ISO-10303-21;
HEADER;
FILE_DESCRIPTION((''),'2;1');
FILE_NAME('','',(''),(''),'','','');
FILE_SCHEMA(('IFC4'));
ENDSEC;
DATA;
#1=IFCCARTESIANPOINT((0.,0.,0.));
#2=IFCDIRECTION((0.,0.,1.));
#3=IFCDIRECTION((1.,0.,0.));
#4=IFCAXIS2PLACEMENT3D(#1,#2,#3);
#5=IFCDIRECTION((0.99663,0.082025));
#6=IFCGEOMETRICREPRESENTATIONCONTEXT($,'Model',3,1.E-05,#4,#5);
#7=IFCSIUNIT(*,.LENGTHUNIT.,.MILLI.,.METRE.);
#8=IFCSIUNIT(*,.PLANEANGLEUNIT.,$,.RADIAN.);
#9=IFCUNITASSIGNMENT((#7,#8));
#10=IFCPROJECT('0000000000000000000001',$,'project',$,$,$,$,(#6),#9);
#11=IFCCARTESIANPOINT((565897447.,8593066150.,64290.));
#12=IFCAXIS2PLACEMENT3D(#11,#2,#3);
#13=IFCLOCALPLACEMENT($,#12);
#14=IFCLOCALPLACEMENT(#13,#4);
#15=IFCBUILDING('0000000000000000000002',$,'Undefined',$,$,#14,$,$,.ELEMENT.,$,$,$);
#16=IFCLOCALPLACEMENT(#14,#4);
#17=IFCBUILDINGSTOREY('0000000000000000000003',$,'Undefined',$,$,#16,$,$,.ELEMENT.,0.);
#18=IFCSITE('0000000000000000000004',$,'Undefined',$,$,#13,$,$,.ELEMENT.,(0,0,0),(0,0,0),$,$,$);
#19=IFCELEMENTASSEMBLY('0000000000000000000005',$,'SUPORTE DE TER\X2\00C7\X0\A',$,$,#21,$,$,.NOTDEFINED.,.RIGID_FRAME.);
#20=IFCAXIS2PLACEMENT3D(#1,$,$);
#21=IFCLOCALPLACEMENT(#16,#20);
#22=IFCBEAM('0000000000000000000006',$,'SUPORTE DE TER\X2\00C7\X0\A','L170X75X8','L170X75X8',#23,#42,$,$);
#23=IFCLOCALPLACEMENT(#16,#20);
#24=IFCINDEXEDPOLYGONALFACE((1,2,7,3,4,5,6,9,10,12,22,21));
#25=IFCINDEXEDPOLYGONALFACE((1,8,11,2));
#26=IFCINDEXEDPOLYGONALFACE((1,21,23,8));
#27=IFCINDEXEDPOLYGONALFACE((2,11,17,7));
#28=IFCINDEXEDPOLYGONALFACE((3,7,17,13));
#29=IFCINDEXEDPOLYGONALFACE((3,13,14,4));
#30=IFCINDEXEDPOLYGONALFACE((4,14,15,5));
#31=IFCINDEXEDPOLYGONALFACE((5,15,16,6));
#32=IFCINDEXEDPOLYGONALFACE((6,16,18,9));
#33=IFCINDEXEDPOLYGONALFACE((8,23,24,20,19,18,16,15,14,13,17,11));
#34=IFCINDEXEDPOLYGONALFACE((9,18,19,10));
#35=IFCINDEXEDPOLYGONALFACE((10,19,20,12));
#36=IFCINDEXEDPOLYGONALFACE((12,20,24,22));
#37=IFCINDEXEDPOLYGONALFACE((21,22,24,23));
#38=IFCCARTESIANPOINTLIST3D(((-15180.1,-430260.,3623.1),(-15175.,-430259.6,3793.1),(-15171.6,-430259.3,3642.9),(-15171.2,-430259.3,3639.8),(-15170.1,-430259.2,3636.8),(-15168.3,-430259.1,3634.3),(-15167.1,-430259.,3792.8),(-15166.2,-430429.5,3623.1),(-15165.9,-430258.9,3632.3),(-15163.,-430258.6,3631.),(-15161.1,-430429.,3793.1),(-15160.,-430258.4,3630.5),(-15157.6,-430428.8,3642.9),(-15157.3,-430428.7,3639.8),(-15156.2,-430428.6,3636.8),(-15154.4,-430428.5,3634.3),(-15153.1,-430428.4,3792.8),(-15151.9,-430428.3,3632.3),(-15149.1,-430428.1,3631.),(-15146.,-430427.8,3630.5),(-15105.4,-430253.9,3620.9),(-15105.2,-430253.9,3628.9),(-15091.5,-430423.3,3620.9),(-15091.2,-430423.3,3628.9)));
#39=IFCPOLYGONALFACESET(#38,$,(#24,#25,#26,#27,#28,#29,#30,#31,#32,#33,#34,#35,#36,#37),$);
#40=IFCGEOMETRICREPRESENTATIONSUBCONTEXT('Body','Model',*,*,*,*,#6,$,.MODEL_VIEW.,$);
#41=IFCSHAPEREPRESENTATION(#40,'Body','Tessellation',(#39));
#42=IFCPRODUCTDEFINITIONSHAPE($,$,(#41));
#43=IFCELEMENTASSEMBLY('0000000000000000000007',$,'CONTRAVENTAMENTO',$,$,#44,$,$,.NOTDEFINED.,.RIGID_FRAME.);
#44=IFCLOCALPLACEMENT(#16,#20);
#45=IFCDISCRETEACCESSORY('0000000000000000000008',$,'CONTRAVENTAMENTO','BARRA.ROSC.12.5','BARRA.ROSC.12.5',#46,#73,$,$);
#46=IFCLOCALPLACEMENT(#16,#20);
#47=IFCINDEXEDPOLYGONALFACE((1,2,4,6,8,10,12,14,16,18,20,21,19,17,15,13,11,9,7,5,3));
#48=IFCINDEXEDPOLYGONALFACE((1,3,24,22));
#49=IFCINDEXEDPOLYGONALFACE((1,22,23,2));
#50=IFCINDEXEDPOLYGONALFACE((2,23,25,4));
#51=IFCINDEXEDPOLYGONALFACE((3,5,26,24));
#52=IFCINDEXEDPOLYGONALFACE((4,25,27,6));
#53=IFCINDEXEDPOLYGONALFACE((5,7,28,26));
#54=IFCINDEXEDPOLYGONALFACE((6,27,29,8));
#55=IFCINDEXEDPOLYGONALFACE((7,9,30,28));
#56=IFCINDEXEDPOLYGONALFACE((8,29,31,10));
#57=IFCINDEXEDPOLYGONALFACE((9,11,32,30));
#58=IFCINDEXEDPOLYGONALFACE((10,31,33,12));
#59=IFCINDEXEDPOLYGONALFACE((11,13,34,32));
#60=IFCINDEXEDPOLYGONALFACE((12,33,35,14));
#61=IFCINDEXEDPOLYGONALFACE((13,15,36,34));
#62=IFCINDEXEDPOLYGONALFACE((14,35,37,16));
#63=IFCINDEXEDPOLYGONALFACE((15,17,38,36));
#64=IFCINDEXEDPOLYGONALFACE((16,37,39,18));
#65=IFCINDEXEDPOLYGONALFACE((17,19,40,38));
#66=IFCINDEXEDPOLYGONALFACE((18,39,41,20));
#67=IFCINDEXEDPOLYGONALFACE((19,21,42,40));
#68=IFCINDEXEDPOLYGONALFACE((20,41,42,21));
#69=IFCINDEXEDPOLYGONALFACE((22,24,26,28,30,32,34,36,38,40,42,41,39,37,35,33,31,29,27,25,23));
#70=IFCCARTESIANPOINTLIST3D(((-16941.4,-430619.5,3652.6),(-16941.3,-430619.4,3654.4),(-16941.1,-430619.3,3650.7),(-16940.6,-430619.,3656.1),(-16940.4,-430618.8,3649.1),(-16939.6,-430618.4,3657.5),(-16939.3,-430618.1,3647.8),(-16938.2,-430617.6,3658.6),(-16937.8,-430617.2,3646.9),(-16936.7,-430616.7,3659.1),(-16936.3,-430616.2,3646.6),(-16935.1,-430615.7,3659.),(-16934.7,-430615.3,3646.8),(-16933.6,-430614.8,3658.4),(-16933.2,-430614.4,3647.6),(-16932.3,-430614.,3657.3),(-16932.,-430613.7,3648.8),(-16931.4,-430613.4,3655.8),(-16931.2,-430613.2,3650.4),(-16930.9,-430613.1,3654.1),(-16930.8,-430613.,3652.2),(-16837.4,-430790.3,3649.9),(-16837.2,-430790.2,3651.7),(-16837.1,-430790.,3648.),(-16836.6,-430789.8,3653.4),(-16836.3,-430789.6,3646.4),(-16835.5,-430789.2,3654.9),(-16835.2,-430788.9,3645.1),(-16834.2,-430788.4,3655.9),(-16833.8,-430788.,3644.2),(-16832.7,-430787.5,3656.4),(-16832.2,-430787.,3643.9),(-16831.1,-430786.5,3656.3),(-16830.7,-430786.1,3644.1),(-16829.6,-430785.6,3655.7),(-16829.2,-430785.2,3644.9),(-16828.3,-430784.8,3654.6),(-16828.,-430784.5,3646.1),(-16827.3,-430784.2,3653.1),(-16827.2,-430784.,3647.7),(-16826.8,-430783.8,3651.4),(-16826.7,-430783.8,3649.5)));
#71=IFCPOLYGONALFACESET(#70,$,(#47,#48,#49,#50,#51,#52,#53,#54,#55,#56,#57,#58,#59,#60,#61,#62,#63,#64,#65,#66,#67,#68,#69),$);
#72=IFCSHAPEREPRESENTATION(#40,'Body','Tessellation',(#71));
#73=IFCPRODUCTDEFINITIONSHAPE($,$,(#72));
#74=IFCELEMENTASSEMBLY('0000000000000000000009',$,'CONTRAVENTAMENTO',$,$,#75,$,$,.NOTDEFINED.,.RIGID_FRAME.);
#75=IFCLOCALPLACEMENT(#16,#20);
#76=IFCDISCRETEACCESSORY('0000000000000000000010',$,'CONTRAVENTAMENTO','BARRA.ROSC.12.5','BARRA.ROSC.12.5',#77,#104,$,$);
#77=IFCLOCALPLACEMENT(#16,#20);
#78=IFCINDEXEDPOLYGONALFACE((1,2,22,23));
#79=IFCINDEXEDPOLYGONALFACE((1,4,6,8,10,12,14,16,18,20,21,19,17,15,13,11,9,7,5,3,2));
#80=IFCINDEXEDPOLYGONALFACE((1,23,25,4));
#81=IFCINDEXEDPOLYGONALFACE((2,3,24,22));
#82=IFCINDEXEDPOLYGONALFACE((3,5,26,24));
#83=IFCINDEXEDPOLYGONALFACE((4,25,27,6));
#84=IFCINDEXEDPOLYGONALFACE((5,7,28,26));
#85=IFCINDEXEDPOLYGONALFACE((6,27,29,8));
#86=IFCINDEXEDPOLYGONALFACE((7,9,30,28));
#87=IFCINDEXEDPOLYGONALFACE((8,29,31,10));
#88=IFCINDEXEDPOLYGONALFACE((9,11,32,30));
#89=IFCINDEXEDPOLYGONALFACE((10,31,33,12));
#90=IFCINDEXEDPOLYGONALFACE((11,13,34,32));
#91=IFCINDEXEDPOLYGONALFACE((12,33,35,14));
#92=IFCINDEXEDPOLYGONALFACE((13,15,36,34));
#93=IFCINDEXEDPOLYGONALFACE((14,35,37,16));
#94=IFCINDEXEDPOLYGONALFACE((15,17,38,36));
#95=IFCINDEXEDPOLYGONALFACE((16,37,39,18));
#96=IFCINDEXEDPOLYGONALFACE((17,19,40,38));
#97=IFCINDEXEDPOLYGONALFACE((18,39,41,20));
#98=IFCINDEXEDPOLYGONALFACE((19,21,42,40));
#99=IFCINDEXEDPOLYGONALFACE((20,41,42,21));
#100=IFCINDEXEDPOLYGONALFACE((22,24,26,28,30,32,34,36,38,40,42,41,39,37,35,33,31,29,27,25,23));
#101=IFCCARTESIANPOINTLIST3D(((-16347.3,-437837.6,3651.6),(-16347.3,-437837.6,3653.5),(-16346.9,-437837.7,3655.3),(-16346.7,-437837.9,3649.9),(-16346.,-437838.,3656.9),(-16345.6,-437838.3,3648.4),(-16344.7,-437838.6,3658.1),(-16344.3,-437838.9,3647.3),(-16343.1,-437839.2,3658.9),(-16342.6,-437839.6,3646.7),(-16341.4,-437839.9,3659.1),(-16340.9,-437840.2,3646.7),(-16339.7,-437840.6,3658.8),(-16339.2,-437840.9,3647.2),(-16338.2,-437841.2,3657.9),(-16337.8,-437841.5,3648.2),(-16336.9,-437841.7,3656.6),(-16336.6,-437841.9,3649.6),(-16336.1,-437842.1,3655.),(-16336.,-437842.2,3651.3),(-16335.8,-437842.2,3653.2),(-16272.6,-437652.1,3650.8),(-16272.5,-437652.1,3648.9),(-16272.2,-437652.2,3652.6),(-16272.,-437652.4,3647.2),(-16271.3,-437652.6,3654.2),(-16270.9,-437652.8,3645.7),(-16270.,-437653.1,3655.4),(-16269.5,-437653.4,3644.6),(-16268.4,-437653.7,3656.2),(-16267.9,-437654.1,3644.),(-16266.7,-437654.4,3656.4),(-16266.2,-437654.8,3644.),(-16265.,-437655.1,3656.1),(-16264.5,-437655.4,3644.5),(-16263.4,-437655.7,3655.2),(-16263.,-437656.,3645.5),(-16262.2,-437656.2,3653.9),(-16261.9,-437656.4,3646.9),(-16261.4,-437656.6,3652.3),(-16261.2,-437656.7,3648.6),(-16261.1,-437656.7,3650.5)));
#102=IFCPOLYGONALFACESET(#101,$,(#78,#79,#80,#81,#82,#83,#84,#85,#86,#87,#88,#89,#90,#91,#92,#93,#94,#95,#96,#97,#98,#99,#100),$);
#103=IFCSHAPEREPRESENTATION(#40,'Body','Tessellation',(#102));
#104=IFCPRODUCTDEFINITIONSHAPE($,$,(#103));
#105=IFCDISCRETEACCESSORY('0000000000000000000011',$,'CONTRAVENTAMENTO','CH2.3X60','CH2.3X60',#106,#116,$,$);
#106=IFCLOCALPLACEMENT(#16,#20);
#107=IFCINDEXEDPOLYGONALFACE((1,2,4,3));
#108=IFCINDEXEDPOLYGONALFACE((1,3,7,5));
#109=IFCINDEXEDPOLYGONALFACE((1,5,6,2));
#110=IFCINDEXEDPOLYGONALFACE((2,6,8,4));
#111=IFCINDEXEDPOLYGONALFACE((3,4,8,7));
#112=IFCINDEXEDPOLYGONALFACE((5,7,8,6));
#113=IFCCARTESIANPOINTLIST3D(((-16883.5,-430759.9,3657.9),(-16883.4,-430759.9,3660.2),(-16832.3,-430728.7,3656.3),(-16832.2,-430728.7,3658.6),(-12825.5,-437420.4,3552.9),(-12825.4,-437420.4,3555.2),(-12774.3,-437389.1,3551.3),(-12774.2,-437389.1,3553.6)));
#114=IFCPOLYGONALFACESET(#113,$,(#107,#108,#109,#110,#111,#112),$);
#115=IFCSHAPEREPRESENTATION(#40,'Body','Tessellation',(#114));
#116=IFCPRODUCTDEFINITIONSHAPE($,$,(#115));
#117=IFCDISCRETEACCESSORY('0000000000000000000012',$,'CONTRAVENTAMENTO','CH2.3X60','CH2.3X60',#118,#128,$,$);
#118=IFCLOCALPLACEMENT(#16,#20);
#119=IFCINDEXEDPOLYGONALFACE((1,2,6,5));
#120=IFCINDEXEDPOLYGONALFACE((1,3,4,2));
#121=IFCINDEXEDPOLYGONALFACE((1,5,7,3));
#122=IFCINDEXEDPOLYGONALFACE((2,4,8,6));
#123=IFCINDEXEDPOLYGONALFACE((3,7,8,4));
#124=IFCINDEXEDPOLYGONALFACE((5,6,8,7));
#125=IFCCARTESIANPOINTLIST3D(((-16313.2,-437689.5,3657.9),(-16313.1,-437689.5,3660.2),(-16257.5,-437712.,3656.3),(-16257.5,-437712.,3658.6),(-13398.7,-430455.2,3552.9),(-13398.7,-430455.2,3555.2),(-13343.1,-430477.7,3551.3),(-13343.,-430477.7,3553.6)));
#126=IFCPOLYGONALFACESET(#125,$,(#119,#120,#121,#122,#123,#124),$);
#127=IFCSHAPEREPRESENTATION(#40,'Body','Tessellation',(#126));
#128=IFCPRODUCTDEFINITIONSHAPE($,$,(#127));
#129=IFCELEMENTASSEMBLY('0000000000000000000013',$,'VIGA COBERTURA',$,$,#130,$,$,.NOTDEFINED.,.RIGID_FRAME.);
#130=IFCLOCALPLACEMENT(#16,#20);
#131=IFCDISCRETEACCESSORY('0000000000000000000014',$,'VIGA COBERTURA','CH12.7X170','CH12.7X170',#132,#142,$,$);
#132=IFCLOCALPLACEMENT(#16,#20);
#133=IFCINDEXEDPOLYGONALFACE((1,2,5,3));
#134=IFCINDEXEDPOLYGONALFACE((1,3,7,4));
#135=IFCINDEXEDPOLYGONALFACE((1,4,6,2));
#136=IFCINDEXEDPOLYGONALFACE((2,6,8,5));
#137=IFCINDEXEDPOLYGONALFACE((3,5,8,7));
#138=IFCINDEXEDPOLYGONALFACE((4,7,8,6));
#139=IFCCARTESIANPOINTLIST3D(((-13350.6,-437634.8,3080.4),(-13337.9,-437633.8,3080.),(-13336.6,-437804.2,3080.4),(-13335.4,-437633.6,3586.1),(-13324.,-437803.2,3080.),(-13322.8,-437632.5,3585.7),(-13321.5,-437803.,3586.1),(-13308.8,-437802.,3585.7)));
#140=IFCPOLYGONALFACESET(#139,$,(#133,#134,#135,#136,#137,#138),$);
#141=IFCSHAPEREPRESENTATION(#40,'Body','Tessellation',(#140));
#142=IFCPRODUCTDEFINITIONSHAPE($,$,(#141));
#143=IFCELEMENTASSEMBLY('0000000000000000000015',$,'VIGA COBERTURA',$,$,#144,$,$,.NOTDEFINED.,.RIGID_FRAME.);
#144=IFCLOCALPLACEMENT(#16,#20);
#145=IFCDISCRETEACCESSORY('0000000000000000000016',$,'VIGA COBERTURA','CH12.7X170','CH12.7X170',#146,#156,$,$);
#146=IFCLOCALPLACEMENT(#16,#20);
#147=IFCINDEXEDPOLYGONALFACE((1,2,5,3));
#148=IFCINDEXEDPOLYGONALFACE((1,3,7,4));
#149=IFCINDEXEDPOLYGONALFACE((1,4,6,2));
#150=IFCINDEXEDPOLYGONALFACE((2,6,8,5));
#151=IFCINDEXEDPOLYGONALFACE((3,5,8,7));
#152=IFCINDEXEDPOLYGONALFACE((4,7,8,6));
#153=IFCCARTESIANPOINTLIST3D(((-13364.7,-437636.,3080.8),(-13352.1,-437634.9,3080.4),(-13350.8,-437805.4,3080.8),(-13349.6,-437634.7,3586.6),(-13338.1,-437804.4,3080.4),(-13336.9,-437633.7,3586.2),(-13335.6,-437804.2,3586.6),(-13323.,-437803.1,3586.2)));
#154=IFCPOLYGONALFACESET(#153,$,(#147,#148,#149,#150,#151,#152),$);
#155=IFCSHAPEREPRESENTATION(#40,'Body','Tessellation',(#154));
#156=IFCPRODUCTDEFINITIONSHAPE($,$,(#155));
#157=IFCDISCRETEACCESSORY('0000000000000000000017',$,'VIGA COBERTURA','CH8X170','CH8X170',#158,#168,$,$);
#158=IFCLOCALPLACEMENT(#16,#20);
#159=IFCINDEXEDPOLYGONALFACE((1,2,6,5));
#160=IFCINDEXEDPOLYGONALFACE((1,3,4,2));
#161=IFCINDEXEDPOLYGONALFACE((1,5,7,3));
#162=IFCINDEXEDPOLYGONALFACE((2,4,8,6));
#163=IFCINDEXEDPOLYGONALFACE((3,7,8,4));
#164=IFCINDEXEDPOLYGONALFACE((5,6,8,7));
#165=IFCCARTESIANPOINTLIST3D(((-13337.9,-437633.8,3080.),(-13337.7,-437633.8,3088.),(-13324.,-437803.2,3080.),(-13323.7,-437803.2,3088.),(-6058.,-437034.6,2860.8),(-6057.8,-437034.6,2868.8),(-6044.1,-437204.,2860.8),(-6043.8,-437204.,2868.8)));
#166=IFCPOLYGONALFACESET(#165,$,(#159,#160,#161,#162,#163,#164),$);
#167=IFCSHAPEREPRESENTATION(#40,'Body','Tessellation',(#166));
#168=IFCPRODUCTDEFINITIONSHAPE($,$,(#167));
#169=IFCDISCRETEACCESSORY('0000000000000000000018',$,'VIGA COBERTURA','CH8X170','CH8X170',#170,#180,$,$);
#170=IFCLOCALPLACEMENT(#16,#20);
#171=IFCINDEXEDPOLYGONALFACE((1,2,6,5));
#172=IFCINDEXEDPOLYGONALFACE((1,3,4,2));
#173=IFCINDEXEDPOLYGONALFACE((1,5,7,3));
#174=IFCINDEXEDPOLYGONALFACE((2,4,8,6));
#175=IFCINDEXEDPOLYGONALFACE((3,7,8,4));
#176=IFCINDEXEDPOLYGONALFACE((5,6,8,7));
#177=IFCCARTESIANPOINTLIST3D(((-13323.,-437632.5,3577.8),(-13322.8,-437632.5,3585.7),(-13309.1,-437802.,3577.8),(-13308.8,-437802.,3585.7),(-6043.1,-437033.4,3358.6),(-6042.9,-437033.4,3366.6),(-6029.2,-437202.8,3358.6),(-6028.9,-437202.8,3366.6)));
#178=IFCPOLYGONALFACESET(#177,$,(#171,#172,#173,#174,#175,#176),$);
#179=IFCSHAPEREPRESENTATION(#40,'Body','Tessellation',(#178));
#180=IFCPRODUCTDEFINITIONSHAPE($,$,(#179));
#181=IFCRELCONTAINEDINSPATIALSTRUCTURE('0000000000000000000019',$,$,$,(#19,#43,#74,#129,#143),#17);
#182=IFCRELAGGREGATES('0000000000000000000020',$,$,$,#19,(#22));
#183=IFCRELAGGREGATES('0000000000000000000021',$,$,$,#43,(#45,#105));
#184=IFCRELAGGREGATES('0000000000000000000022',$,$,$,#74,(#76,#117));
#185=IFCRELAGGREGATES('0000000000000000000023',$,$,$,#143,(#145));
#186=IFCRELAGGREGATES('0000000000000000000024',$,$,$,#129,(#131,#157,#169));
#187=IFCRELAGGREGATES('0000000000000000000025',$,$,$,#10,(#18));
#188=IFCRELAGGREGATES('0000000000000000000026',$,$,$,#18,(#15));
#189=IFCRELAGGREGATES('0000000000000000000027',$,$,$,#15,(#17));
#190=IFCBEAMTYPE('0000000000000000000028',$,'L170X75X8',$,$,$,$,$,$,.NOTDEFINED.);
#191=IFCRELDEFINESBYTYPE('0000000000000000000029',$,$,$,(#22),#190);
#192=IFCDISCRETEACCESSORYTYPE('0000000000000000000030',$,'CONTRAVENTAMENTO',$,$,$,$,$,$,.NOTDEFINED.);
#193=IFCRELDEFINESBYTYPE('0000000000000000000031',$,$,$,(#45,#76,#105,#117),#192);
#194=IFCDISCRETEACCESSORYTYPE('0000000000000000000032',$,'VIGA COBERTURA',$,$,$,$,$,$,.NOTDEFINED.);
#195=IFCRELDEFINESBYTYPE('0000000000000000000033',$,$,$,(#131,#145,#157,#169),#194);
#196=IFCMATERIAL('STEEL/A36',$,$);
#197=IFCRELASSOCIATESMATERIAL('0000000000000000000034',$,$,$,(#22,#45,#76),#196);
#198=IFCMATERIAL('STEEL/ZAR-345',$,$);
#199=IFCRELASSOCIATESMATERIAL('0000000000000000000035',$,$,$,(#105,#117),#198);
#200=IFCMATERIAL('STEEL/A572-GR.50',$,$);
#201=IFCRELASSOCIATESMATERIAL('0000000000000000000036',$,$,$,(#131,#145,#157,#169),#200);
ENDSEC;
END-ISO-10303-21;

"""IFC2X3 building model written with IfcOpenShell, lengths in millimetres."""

from ifc_helpers import new_model, si_unit, direction, frame, origin_with_axes, origin_2d_with_axis, place, context, subcontext, project, spatial, polyline, rectangle, circle, l_section, outline, extrude, material, type_object, element, aggregate, save


model = new_model("IFC2X3")

# Units and contexts
model_context = context("Model", 3, precision=1e-05, world=origin_with_axes(), true_north=direction((0.99663, 0.082025)))
body_context = subcontext(model_context, "Body", "Model", "MODEL_VIEW")
ifc_project = project(units=[si_unit("LENGTHUNIT", "METRE", prefix="MILLI"), si_unit("PLANEANGLEUNIT", "RADIAN")], contexts=[model_context])

# Site, building, storey
site_placement = place(None, frame((565897447.0, 8593066150.0, 64290.0), z_axis=(0.0, 0.0, 1.0), x_axis=(1.0, 0.0, 0.0)))
site = spatial("IfcSite", under=ifc_project, at=site_placement, Name="Undefined", CompositionType="ELEMENT", RefLatitude=(0, 0, 0), RefLongitude=(0, 0, 0))
building_placement = place(site_placement, origin_with_axes())
building = spatial("IfcBuilding", under=site, at=building_placement, Name="Undefined", CompositionType="ELEMENT")
storey_placement = place(building_placement, origin_with_axes())
storey = spatial("IfcBuildingStorey", under=building, at=storey_placement, Name="Undefined", CompositionType="ELEMENT", Elevation=0.0)

# Element assembly, beam
ifc_material_1 = material(Name="STEEL/A36")
assembly_1_placement = place(storey_placement, origin_with_axes())
assembly_1 = element("IfcElementAssembly", 1, at=assembly_1_placement, inside=storey, Name="SUPORTE DE TERÇA", AssemblyPlace="NOTDEFINED", PredefinedType="RIGID_FRAME")
beam_type_1 = type_object("IfcBeamType", Name="L170X75X8", PredefinedType="NOTDEFINED")
beam_1_placement = place(assembly_1_placement, frame((-15126.3, -430426.2, 3707.0), z_axis=(0.029885, 0.00246, 0.99955), x_axis=(-0.082025, 0.99663, 0.0)))
beam_1 = element("IfcBeam", 2, at=beam_1_placement, type_object=beam_type_1, material=ifc_material_1, Name="SUPORTE DE TERÇA", Description="L170X75X8", ObjectType="L170X75X8", context=body_context, shape_type="SweptSolid", body=[
    extrude(l_section(Depth=170.0, Width=75.0, Thickness=8.0, FilletRadius=12.0, at=origin_2d_with_axis()), frame((170.0, 0.0, 0.0), z_axis=(-1.0, 0.0, 0.0), x_axis=(0.0, -1.0, 0.0)), (0.0, 0.0, 1.0), 170.0),
])
aggregate(assembly_1, [beam_1])

# Element assemblies, discrete accessories
assembly_2_placement = place(storey_placement, origin_with_axes())
assembly_2 = element("IfcElementAssembly", 3, at=assembly_2_placement, inside=storey, Name="CONTRAVENTAMENTO", AssemblyPlace="NOTDEFINED", PredefinedType="RIGID_FRAME")
discrete_accessory_type_1 = type_object("IfcDiscreteAccessoryType", Name="CONTRAVENTAMENTO")
discrete_accessory_1_placement = place(assembly_2_placement, frame((-16936.1, -430616.2, 3652.9), z_axis=(-0.853486, -0.520426, 0.026799), x_axis=(0.520257, -0.853904, -0.013454)))
discrete_accessory_1 = element("IfcDiscreteAccessory", 4, at=discrete_accessory_1_placement, type_object=discrete_accessory_type_1, material=ifc_material_1, Name="CONTRAVENTAMENTO", Description="BARRA.ROSC.12.5", ObjectType="BARRA.ROSC.12.5", context=body_context, shape_type="SweptSolid", body=[
    extrude(circle(Radius=6.2, at=origin_2d_with_axis()), frame((200.0, 0.0, 0.0), z_axis=(-1.0, 0.0, 0.0), x_axis=(0.0, -1.0, 0.0)), (0.0, 0.0, 1.0), 200.0),
])
assembly_3_placement = place(storey_placement, origin_with_axes())
assembly_3 = element("IfcElementAssembly", 5, at=assembly_3_placement, inside=storey, Name="CONTRAVENTAMENTO", AssemblyPlace="NOTDEFINED", PredefinedType="RIGID_FRAME")
discrete_accessory_2_placement = place(assembly_3_placement, frame((-16341.6, -437839.9, 3652.9), z_axis=(-0.92709, 0.373879, 0.026799), x_axis=(0.373645, 0.927474, -0.013454)))
discrete_accessory_2 = element("IfcDiscreteAccessory", 6, at=discrete_accessory_2_placement, type_object=discrete_accessory_type_1, material=ifc_material_1, Name="CONTRAVENTAMENTO", Description="BARRA.ROSC.12.5", ObjectType="BARRA.ROSC.12.5", context=body_context, shape_type="SweptSolid", body=[
    extrude(circle(Radius=6.2, at=origin_2d_with_axis()), frame((200.0, 0.0, 0.0), z_axis=(-1.0, 0.0, 0.0), x_axis=(0.0, -1.0, 0.0)), (0.0, 0.0, 1.0), 200.0),
])

# Discrete accessories
ifc_material_2 = material(Name="STEEL/ZAR-345")
discrete_accessory_3_placement = place(assembly_2_placement, frame((-12799.8, -437404.7, 3553.3), z_axis=(0.029885, 0.00246, 0.99955), x_axis=(-0.520257, 0.853903, 0.013454)))
discrete_accessory_3 = element("IfcDiscreteAccessory", 7, at=discrete_accessory_3_placement, type_object=discrete_accessory_type_1, material=ifc_material_2, Name="CONTRAVENTAMENTO", Description="CH2.3X60", ObjectType="CH2.3X60", context=body_context, shape_type="SweptSolid", body=[
    extrude(outline(polyline([(7800.0, -30.0), (0.0, -30.0), (0.0, 30.0), (7800.0, 30.0), (7800.0, -30.0)])), frame((0.0, 0.0, -1.1), z_axis=(0.0, 0.0, 1.0), x_axis=(1.0, 0.0, 0.0)), (0.0, 0.0, 1.0), 2.3),
])
aggregate(assembly_2, [discrete_accessory_1, discrete_accessory_3])
discrete_accessory_4_placement = place(assembly_3_placement, frame((-13370.9, -430466.4, 3553.3), z_axis=(-0.029885, -0.00246, -0.99955), x_axis=(-0.373645, -0.927474, 0.013454)))
discrete_accessory_4 = element("IfcDiscreteAccessory", 8, at=discrete_accessory_4_placement, type_object=discrete_accessory_type_1, material=ifc_material_2, Name="CONTRAVENTAMENTO", Description="CH2.3X60", ObjectType="CH2.3X60", context=body_context, shape_type="SweptSolid", body=[
    extrude(outline(polyline([(0.0, 30.0), (7800.0, 30.0), (7800.0, -30.0), (0.0, -30.0), (0.0, 30.0)])), frame((0.0, 0.0, -1.1), z_axis=(0.0, 0.0, 1.0), x_axis=(1.0, 0.0, 0.0)), (0.0, 0.0, 1.0), 2.3),
])
aggregate(assembly_3, [discrete_accessory_2, discrete_accessory_4])

# Element assemblies, discrete accessories
assembly_4_placement = place(storey_placement, origin_with_axes())
assembly_4 = element("IfcElementAssembly", 9, at=assembly_4_placement, inside=storey, Name="VIGA COBERTURA", AssemblyPlace="NOTDEFINED", PredefinedType="RIGID_FRAME")
ifc_material_3 = material(Name="STEEL/A572-GR.50")
discrete_accessory_type_2 = type_object("IfcDiscreteAccessoryType", Name="VIGA COBERTURA")
discrete_accessory_5_placement = place(assembly_4_placement, frame((-13322.1, -437717.8, 3585.9), z_axis=(-0.082025, 0.99663, 0.0), x_axis=(-0.029885, -0.00246, -0.99955)))
discrete_accessory_5 = element("IfcDiscreteAccessory", 10, at=discrete_accessory_5_placement, type_object=discrete_accessory_type_2, material=ifc_material_3, Name="VIGA COBERTURA", Description="CH12.7X170", ObjectType="CH12.7X170", context=body_context, shape_type="SweptSolid", body=[
    extrude(rectangle(XDim=12.7, YDim=170.0, at=origin_2d_with_axis()), frame((506.0, 0.0, 0.0), z_axis=(-1.0, 0.0, 0.0), x_axis=(0.0, -1.0, 0.0)), (0.0, 0.0, 1.0), 506.0),
])
assembly_5_placement = place(storey_placement, origin_with_axes())
assembly_5 = element("IfcElementAssembly", 11, at=assembly_5_placement, inside=storey, Name="VIGA COBERTURA", AssemblyPlace="NOTDEFINED", PredefinedType="RIGID_FRAME")
discrete_accessory_6_placement = place(assembly_5_placement, frame((-13336.3, -437718.9, 3586.4), z_axis=(-0.082025, 0.99663, 0.0), x_axis=(-0.029885, -0.00246, -0.99955)))
discrete_accessory_6 = element("IfcDiscreteAccessory", 12, at=discrete_accessory_6_placement, type_object=discrete_accessory_type_2, material=ifc_material_3, Name="VIGA COBERTURA", Description="CH12.7X170", ObjectType="CH12.7X170", context=body_context, shape_type="SweptSolid", body=[
    extrude(rectangle(XDim=12.7, YDim=170.0, at=origin_2d_with_axis()), frame((506.0, 0.0, 0.0), z_axis=(-1.0, 0.0, 0.0), x_axis=(0.0, -1.0, 0.0)), (0.0, 0.0, 1.0), 506.0),
])

# Discrete accessories
discrete_accessory_7_placement = place(assembly_4_placement, frame((-13330.8, -437718.5, 3084.0), z_axis=(-0.029885, -0.00246, -0.99955), x_axis=(0.996182, 0.081989, -0.029987)))
discrete_accessory_7 = element("IfcDiscreteAccessory", 13, at=discrete_accessory_7_placement, type_object=discrete_accessory_type_2, material=ifc_material_3, Name="VIGA COBERTURA", Description="CH8X170", ObjectType="CH8X170", context=body_context, shape_type="SweptSolid", body=[
    extrude(outline(polyline([(0.0, -85.0), (0.0, 85.0), (7307.8, 85.0), (7307.8, -85.0), (0.0, -85.0)])), frame((0.0, 0.0, -4.0), z_axis=(0.0, 0.0, 1.0), x_axis=(1.0, 0.0, 0.0)), (0.0, 0.0, 1.0), 8.0),
])
aggregate(assembly_5, [discrete_accessory_6])
discrete_accessory_8_placement = place(assembly_4_placement, frame((-13315.9, -437717.3, 3581.7), z_axis=(-0.029885, -0.00246, -0.99955), x_axis=(0.996182, 0.081989, -0.029987)))
discrete_accessory_8 = element("IfcDiscreteAccessory", 14, at=discrete_accessory_8_placement, type_object=discrete_accessory_type_2, material=ifc_material_3, Name="VIGA COBERTURA", Description="CH8X170", ObjectType="CH8X170", context=body_context, shape_type="SweptSolid", body=[
    extrude(outline(polyline([(0.0, -85.0), (0.0, 85.0), (7307.8, 85.0), (7307.8, -85.0), (0.0, -85.0)])), frame((0.0, 0.0, -4.0), z_axis=(0.0, 0.0, 1.0), x_axis=(1.0, 0.0, 0.0)), (0.0, 0.0, 1.0), 8.0),
])
aggregate(assembly_4, [discrete_accessory_5, discrete_accessory_7, discrete_accessory_8])

save(model, "model.ifc")
